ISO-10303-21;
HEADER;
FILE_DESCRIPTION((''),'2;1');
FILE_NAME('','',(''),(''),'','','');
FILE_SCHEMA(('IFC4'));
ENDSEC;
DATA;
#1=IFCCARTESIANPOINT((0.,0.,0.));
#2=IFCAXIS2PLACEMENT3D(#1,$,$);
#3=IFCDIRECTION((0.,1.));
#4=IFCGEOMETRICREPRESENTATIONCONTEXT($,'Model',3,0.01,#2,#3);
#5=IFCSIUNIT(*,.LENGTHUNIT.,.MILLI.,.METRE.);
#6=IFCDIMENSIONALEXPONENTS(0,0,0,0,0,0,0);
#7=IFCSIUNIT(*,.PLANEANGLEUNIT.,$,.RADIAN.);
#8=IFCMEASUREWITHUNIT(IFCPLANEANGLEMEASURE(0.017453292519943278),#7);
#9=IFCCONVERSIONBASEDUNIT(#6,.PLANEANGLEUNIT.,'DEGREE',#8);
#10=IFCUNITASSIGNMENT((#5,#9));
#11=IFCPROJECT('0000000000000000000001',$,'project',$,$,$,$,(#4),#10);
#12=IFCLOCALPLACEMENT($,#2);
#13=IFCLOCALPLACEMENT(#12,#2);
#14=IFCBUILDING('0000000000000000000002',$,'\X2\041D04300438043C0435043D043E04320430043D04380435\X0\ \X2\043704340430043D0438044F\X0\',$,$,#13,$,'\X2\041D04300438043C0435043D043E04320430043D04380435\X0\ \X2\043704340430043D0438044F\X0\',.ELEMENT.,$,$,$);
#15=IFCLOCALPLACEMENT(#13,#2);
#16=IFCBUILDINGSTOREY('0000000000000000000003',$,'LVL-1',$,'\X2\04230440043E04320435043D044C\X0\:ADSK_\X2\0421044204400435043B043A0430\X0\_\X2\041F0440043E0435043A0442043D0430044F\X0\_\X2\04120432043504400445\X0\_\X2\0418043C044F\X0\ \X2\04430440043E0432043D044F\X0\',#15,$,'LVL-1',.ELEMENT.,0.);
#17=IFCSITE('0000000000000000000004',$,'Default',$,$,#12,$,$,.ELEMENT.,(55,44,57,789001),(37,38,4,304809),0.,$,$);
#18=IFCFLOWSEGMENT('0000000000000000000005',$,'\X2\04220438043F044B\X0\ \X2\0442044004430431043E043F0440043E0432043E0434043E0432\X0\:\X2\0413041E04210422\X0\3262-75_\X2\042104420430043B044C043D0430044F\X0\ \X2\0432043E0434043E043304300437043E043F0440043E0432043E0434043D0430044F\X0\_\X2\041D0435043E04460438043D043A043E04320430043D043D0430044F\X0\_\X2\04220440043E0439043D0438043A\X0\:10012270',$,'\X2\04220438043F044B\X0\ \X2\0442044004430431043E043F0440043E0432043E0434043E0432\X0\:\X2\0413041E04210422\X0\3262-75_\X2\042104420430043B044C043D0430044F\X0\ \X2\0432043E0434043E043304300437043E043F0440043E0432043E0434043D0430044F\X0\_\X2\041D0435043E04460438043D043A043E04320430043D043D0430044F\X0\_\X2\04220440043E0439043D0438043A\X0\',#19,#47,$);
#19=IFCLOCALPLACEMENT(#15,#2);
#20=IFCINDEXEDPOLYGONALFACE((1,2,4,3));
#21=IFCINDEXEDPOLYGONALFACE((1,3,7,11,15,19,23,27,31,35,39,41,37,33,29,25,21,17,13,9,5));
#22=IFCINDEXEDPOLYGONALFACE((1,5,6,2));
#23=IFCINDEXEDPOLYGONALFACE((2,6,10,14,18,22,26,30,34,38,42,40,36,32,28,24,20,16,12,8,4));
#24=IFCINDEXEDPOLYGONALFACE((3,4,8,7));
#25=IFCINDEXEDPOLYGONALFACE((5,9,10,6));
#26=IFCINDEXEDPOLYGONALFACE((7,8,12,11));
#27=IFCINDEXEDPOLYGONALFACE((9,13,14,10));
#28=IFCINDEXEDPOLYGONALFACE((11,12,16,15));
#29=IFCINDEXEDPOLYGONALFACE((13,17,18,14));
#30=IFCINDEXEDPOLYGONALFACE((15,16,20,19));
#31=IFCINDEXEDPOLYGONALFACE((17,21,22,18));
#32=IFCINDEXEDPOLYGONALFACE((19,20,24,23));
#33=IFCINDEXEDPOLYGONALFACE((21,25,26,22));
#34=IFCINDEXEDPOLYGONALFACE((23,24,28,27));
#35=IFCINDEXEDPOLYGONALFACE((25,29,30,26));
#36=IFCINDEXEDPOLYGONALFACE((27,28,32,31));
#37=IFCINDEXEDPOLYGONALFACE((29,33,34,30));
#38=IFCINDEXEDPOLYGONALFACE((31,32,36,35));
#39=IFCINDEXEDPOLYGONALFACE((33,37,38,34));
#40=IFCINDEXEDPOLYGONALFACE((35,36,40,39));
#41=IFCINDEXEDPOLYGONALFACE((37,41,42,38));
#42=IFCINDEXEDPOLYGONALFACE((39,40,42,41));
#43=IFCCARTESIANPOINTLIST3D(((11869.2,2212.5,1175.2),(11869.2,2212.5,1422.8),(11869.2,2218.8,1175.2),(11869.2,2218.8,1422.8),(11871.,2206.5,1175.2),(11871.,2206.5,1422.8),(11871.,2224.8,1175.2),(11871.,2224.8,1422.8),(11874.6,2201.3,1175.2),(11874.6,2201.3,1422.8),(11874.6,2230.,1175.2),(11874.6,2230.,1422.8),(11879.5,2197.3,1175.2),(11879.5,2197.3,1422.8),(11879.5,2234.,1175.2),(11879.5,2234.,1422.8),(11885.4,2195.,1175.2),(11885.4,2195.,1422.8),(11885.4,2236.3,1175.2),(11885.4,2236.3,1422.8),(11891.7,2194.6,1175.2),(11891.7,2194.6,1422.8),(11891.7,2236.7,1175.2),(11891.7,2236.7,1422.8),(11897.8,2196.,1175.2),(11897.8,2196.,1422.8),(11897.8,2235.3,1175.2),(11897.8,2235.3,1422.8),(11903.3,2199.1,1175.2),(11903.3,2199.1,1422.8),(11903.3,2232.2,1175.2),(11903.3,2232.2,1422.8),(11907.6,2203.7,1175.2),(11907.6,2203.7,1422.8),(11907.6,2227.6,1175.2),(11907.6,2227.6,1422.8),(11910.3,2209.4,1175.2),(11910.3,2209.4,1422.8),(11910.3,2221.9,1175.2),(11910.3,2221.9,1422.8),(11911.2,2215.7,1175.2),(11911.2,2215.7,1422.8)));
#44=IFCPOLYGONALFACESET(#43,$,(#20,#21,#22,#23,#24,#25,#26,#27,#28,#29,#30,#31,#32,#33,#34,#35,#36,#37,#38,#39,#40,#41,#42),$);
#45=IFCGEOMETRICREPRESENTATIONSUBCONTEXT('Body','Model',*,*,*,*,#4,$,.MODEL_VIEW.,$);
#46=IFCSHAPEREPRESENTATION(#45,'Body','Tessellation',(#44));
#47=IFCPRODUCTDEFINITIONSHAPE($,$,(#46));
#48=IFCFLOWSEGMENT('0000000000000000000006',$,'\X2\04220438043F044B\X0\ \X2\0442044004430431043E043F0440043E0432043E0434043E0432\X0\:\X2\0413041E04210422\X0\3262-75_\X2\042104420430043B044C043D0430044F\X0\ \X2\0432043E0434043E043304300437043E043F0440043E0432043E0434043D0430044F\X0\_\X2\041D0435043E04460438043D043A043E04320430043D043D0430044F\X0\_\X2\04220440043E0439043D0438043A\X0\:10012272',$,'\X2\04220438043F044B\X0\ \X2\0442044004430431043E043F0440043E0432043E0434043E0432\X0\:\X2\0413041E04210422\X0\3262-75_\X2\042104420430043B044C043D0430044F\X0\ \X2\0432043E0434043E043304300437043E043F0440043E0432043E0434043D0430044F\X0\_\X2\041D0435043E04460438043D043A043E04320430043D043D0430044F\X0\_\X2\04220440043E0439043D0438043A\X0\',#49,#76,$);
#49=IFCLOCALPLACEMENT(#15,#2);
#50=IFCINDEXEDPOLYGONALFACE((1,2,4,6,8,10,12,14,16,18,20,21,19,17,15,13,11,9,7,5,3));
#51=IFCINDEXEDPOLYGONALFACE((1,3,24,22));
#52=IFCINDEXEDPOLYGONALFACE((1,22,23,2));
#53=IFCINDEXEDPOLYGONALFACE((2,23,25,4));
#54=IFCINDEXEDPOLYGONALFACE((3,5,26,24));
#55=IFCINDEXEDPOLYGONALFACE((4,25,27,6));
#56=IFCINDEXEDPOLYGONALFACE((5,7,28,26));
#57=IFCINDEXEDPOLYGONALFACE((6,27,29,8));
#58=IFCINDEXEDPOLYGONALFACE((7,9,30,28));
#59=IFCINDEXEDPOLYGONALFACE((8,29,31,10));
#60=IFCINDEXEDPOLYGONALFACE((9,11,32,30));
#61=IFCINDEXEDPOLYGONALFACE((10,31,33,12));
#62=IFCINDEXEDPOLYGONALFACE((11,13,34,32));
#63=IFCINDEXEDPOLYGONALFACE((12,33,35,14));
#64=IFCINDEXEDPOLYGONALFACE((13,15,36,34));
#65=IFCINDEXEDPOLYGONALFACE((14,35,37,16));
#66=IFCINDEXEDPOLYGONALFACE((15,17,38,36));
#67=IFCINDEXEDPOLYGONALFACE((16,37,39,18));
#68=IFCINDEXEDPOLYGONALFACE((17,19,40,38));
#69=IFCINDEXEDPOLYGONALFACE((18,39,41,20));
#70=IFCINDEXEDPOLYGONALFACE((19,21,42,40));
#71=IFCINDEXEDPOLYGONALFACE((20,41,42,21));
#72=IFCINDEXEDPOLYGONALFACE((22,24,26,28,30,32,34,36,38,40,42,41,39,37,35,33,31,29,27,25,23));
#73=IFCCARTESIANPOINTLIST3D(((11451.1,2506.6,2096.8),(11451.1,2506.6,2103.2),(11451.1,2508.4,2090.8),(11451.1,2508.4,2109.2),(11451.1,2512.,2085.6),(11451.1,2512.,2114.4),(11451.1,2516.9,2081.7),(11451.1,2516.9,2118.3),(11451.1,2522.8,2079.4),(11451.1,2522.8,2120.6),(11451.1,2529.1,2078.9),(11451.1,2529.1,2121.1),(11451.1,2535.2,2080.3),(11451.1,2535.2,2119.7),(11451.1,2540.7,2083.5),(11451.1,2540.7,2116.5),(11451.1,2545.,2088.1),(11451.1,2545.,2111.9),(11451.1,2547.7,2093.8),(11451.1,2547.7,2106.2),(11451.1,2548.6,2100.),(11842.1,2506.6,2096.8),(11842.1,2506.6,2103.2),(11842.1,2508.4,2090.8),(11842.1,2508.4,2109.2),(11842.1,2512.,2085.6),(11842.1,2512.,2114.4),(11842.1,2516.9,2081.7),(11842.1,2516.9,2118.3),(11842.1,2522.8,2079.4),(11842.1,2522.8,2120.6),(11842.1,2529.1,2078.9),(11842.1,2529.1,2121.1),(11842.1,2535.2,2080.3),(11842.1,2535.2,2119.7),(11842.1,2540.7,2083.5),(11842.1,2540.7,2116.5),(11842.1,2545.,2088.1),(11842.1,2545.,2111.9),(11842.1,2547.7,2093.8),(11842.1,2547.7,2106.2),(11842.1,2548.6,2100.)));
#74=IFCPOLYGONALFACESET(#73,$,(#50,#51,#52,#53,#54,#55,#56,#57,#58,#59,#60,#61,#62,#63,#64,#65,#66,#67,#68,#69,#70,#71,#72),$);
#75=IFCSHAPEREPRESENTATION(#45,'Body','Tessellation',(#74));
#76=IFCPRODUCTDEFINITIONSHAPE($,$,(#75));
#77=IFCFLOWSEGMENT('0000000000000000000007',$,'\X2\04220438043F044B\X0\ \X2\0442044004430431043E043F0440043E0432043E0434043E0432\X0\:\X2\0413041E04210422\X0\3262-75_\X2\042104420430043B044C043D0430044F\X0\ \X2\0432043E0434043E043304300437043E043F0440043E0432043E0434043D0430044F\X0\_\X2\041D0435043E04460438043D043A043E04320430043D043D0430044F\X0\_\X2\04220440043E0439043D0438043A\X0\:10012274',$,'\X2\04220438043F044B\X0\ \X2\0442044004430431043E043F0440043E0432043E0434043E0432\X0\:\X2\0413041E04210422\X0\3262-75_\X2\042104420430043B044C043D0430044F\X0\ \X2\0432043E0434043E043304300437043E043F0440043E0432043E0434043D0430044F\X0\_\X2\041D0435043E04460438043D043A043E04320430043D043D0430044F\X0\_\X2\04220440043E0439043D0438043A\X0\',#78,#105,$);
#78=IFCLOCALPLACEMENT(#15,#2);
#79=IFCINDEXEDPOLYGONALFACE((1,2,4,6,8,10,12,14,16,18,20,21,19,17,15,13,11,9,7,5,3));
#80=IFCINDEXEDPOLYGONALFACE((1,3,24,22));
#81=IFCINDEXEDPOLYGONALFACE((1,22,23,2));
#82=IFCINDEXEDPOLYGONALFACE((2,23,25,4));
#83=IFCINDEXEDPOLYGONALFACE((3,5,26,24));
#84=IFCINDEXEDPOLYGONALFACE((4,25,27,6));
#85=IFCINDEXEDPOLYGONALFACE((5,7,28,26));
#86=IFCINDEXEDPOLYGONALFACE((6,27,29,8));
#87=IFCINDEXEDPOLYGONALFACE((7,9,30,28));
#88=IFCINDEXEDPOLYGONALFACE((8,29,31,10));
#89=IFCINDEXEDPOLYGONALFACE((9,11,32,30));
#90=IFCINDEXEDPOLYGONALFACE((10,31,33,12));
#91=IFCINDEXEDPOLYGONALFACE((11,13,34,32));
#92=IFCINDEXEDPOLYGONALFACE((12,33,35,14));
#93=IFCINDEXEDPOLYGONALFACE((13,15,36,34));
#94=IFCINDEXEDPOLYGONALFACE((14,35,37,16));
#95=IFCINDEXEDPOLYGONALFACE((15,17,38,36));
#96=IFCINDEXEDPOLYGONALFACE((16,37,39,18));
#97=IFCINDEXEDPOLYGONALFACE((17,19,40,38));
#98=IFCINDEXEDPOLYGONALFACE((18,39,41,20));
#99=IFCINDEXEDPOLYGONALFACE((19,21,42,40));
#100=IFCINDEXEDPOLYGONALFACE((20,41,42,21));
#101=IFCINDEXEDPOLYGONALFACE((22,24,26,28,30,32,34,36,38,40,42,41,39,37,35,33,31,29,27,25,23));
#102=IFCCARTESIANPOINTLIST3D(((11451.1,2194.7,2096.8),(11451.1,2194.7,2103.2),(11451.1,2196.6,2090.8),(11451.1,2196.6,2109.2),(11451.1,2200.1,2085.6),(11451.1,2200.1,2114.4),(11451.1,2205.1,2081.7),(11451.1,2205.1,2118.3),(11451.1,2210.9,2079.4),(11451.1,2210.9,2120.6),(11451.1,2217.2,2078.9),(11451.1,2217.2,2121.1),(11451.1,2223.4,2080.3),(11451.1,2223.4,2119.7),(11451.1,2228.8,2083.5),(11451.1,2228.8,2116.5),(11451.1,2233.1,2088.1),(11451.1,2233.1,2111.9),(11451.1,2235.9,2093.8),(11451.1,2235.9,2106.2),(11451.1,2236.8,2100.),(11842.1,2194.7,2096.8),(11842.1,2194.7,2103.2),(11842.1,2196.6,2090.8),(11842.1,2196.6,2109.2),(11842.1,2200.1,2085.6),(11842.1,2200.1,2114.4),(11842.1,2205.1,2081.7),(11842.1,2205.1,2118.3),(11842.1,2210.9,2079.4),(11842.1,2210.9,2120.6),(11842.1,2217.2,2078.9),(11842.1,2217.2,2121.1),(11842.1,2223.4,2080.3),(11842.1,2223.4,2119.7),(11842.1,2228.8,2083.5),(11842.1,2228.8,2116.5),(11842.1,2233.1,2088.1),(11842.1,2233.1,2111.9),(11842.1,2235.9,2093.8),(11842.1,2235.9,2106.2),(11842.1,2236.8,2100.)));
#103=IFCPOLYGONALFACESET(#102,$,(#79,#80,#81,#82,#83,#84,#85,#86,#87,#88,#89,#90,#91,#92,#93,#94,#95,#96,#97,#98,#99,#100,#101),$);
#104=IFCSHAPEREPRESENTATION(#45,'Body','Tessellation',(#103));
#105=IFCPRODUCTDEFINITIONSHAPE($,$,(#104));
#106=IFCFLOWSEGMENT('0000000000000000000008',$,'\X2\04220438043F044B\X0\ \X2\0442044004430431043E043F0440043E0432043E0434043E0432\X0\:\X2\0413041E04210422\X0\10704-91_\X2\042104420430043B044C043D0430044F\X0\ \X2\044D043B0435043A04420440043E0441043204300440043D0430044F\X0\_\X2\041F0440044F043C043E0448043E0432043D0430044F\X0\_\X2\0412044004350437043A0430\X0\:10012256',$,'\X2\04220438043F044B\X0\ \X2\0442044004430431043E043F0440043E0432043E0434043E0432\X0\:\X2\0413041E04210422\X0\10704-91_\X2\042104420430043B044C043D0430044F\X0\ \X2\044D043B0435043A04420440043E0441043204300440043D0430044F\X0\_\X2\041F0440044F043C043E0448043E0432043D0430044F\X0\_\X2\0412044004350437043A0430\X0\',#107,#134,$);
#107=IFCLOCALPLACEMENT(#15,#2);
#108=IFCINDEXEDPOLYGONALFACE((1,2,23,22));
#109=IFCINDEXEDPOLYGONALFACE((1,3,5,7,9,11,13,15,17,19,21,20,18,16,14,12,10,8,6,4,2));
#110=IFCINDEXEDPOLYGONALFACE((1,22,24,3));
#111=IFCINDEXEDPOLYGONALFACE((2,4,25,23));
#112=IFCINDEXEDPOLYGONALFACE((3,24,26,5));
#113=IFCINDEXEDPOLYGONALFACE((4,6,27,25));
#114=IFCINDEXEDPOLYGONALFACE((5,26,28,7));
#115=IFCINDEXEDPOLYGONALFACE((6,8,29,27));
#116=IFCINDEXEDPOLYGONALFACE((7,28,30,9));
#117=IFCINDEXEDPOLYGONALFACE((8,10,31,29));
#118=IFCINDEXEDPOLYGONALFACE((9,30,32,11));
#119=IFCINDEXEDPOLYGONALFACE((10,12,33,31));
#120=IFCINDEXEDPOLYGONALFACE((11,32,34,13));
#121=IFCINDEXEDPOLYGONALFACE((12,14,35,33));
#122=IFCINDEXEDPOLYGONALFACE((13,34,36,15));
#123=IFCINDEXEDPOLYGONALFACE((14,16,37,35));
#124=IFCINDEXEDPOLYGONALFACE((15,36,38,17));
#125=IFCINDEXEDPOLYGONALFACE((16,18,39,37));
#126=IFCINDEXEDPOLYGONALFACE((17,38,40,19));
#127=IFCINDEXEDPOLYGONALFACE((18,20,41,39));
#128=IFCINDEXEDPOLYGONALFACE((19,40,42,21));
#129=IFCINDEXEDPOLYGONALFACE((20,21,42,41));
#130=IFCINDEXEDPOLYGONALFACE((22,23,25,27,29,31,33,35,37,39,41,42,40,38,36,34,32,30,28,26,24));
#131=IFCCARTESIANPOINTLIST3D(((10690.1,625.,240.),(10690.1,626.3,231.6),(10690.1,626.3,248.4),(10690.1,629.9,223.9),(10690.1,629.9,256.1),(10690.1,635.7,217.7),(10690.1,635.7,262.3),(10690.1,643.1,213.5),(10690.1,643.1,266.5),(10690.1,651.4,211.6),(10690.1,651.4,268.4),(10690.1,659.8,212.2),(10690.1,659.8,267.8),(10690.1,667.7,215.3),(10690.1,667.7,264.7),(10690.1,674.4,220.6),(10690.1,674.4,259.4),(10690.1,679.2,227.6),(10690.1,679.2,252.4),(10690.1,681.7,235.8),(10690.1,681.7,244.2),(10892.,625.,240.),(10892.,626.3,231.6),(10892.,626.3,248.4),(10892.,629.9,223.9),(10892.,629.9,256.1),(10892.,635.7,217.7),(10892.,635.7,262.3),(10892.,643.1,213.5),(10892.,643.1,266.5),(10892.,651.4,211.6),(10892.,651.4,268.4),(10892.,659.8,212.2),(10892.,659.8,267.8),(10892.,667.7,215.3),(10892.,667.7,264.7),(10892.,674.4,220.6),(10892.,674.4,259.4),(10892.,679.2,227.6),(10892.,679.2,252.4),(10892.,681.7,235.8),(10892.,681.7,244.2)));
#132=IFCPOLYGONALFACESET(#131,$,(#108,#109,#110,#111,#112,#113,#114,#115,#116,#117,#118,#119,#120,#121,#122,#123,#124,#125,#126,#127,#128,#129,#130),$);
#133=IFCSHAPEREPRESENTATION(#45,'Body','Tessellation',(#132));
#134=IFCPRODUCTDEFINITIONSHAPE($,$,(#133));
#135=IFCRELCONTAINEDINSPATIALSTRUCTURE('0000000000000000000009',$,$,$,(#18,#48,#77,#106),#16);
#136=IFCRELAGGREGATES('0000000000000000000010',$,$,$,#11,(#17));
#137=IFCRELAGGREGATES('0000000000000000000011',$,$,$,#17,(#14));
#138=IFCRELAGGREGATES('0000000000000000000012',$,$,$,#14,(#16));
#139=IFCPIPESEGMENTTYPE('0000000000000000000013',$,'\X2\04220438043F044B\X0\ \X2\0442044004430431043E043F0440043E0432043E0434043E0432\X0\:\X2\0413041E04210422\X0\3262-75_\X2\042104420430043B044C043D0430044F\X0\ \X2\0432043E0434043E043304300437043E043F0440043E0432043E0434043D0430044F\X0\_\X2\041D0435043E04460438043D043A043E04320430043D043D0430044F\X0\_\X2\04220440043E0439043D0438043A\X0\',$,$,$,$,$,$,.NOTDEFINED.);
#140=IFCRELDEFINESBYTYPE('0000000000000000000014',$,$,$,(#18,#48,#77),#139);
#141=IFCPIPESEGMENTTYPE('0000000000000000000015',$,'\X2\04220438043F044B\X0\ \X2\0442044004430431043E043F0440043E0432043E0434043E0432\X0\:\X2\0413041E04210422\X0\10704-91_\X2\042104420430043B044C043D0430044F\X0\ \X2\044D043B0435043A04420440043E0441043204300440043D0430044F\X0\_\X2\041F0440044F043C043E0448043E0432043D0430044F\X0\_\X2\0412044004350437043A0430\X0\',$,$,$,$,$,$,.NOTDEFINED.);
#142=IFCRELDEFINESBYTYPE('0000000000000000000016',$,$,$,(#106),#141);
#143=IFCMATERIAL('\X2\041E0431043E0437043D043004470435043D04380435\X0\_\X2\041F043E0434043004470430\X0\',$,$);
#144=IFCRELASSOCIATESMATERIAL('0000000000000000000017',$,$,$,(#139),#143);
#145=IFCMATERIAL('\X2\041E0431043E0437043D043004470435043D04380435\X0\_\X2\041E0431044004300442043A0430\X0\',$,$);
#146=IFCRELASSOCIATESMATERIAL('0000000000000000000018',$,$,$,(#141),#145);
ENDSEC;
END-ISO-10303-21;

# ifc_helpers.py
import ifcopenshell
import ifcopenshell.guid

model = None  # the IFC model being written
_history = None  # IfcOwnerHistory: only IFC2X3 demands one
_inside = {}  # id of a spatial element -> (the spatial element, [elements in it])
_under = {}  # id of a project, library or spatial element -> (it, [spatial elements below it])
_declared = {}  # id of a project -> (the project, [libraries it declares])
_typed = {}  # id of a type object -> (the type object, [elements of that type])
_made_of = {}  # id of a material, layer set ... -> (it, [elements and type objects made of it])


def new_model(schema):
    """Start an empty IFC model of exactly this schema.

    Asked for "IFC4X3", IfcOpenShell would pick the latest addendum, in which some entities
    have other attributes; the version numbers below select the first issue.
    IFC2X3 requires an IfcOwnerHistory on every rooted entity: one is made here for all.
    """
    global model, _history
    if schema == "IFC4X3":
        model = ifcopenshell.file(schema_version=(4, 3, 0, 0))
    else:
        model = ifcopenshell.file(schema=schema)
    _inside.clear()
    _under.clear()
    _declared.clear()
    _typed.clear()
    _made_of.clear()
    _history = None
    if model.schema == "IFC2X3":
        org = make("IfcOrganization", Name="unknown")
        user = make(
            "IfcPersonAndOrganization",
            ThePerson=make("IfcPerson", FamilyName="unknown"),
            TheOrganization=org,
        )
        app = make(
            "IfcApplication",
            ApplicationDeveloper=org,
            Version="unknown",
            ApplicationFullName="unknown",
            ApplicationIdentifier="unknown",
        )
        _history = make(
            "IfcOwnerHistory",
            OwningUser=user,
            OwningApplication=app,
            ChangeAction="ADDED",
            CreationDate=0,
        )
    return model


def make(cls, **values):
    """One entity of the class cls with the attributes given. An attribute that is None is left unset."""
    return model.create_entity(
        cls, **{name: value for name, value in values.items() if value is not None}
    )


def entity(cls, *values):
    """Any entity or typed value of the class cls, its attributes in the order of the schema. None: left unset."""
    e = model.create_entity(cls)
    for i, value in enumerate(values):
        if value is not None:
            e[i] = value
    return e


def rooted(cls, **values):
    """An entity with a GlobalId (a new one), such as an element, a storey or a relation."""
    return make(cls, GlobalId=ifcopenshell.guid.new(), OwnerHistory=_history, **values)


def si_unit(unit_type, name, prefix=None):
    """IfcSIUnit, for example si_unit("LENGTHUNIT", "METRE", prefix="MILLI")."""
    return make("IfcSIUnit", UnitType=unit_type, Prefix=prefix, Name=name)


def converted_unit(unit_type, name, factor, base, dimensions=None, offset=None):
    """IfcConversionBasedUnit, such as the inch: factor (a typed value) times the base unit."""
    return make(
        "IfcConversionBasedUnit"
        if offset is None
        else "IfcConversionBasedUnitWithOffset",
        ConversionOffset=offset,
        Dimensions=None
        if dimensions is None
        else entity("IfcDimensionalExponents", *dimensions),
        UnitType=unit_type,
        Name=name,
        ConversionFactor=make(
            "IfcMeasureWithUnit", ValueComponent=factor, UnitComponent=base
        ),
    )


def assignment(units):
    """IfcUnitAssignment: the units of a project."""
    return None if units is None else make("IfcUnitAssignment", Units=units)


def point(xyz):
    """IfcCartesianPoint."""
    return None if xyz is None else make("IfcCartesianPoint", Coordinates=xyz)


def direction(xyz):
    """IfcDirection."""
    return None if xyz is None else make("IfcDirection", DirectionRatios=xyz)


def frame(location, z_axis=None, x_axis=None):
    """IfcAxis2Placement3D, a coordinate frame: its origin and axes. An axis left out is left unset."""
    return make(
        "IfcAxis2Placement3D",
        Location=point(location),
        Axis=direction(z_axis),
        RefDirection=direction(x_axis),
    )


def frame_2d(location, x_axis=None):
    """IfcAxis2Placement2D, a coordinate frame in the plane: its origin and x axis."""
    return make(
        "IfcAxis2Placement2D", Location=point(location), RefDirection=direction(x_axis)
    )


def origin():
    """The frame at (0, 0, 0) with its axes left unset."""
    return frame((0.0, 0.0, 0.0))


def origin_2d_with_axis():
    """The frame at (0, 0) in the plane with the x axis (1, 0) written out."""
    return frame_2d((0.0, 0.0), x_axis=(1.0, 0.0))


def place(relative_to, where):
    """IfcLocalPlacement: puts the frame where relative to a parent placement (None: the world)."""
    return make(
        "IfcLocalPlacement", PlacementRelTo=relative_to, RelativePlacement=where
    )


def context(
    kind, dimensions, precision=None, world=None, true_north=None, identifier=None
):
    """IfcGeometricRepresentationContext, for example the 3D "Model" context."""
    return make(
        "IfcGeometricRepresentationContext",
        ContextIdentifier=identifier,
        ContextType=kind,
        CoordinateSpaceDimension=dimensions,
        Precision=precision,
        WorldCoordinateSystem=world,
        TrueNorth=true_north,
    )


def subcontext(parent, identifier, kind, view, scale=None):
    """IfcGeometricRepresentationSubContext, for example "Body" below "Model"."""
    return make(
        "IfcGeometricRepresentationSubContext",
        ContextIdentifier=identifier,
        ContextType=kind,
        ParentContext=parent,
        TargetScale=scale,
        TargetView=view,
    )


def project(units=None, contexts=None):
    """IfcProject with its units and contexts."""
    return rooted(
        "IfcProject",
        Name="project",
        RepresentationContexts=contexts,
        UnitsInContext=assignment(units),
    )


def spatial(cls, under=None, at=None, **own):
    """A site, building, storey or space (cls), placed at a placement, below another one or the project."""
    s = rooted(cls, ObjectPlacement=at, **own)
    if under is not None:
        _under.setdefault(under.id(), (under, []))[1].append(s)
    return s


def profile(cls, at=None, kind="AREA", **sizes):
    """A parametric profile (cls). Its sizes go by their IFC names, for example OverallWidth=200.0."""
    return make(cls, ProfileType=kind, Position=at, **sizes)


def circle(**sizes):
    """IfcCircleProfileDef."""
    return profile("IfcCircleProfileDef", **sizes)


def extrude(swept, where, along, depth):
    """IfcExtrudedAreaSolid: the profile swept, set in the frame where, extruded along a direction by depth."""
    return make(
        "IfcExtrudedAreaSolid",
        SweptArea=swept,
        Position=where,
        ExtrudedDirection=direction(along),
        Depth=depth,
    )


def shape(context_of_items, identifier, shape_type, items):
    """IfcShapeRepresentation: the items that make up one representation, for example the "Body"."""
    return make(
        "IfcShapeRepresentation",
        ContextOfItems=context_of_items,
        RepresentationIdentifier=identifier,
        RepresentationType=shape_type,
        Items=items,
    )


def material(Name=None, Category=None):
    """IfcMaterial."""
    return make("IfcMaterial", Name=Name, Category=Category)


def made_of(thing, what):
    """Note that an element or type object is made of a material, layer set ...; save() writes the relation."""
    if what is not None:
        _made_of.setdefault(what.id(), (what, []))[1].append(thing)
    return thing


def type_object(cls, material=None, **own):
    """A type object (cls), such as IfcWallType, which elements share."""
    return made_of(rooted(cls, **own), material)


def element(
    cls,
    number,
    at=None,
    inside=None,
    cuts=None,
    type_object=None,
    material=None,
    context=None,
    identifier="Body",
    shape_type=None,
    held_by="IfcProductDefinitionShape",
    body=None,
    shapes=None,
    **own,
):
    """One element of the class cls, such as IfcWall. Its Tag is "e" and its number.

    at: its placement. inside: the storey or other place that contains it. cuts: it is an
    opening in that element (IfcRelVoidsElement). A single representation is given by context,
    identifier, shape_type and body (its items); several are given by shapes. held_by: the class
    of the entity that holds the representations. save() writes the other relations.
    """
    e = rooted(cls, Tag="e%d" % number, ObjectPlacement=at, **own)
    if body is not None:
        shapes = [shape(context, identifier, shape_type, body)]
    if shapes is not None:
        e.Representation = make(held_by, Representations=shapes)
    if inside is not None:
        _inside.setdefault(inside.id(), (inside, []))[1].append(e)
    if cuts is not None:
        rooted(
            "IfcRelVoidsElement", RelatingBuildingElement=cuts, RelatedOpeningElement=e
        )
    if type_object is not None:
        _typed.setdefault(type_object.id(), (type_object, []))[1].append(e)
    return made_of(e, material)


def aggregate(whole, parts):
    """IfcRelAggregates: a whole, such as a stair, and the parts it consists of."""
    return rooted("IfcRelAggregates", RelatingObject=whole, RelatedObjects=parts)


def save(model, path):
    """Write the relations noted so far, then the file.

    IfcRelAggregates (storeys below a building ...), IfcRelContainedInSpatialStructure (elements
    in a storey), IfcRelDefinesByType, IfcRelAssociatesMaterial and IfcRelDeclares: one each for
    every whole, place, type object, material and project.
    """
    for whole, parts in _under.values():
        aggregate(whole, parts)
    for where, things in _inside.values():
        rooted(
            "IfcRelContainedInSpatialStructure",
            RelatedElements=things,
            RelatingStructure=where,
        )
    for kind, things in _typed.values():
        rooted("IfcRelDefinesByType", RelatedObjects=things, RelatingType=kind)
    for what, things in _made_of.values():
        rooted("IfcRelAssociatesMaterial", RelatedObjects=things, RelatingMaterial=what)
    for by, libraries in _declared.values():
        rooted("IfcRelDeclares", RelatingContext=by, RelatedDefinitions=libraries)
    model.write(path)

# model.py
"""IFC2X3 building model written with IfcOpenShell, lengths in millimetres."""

from ifc_helpers import new_model, entity, si_unit, converted_unit, direction, frame, frame_2d, origin, origin_2d_with_axis, place, context, subcontext, project, spatial, circle, extrude, material, type_object, element, save


model = new_model("IFC2X3")

# Units and contexts
model_context = context("Model", 3, precision=0.01, world=origin(), true_north=direction((0.0, 1.0)))
body_context = subcontext(model_context, "Body", "Model", "MODEL_VIEW")
ifc_project = project(units=[si_unit("LENGTHUNIT", "METRE", prefix="MILLI"), converted_unit("PLANEANGLEUNIT", "DEGREE", entity("IfcPlaneAngleMeasure", 0.017453292519943278), si_unit("PLANEANGLEUNIT", "RADIAN"), dimensions=[0, 0, 0, 0, 0, 0, 0])], contexts=[model_context])

# Site, building, storey
site_placement = place(None, origin())
site = spatial("IfcSite", under=ifc_project, at=site_placement, Name="Default", CompositionType="ELEMENT", RefLatitude=(55, 44, 57, 789001), RefLongitude=(37, 38, 4, 304809), RefElevation=0.0)
building_placement = place(site_placement, origin())
building = spatial("IfcBuilding", under=site, at=building_placement, Name="Наименование здания", LongName="Наименование здания", CompositionType="ELEMENT")
storey_placement = place(building_placement, origin())
storey = spatial("IfcBuildingStorey", under=building, at=storey_placement, Name="LVL-1", ObjectType="Уровень:ADSK_Стрелка_Проектная_Вверх_Имя уровня", LongName="LVL-1", CompositionType="ELEMENT", Elevation=0.0)

# Flow segments
ifc_material_1 = material(Name="Обозначение_Подача")
pipe_segment_type_1 = type_object("IfcPipeSegmentType", Name="Типы трубопроводов:ГОСТ3262-75_Стальная водогазопроводная_Неоцинкованная_Тройник", PredefinedType="NOTDEFINED", material=ifc_material_1)
flow_segment_1_placement = place(storey_placement, origin())
element("IfcFlowSegment", 1, at=flow_segment_1_placement, inside=storey, type_object=pipe_segment_type_1, Name="Типы трубопроводов:ГОСТ3262-75_Стальная водогазопроводная_Неоцинкованная_Тройник:10012270", ObjectType="Типы трубопроводов:ГОСТ3262-75_Стальная водогазопроводная_Неоцинкованная_Тройник", context=body_context, shape_type="SweptSolid", body=[
    extrude(circle(Radius=21.1, at=origin_2d_with_axis()), frame((11890.1, 2215.7, 1175.2)), (0.0, 0.0, 1.0), 247.6),
])
flow_segment_2_placement = place(storey_placement, origin())
element("IfcFlowSegment", 2, at=flow_segment_2_placement, inside=storey, type_object=pipe_segment_type_1, Name="Типы трубопроводов:ГОСТ3262-75_Стальная водогазопроводная_Неоцинкованная_Тройник:10012272", ObjectType="Типы трубопроводов:ГОСТ3262-75_Стальная водогазопроводная_Неоцинкованная_Тройник", context=body_context, shape_type="SweptSolid", body=[
    extrude(circle(Radius=21.1, at=frame_2d((0.0, 0.0), x_axis=(1.0, 0.0))), frame((11451.1, 2527.5, 2100.0), z_axis=(1.0, 0.0, 0.0), x_axis=(0.0, 1.0, 0.0)), (0.0, 0.0, 1.0), 391.0),
])
flow_segment_3_placement = place(storey_placement, origin())
element("IfcFlowSegment", 3, at=flow_segment_3_placement, inside=storey, type_object=pipe_segment_type_1, Name="Типы трубопроводов:ГОСТ3262-75_Стальная водогазопроводная_Неоцинкованная_Тройник:10012274", ObjectType="Типы трубопроводов:ГОСТ3262-75_Стальная водогазопроводная_Неоцинкованная_Тройник", context=body_context, shape_type="SweptSolid", body=[
    extrude(circle(Radius=21.1, at=frame_2d((0.0, 0.0), x_axis=(1.0, 0.0))), frame((11451.1, 2215.7, 2100.0), z_axis=(1.0, 0.0, 0.0), x_axis=(0.0, 1.0, 0.0)), (0.0, 0.0, 1.0), 391.0),
])
ifc_material_2 = material(Name="Обозначение_Обратка")
pipe_segment_type_2 = type_object("IfcPipeSegmentType", Name="Типы трубопроводов:ГОСТ10704-91_Стальная электросварная_Прямошовная_Врезка", PredefinedType="NOTDEFINED", material=ifc_material_2)
flow_segment_4_placement = place(storey_placement, origin())
element("IfcFlowSegment", 4, at=flow_segment_4_placement, inside=storey, type_object=pipe_segment_type_2, Name="Типы трубопроводов:ГОСТ10704-91_Стальная электросварная_Прямошовная_Врезка:10012256", ObjectType="Типы трубопроводов:ГОСТ10704-91_Стальная электросварная_Прямошовная_Врезка", context=body_context, shape_type="SweptSolid", body=[
    extrude(circle(Radius=28.5, at=frame_2d((0.0, 0.0), x_axis=(1.0, 0.0))), frame((10690.1, 653.5, 240.0), z_axis=(1.0, 0.0, 0.0), x_axis=(0.0, -1.0, 0.0)), (0.0, 0.0, 1.0), 201.9),
])

save(model, "model.ifc")
